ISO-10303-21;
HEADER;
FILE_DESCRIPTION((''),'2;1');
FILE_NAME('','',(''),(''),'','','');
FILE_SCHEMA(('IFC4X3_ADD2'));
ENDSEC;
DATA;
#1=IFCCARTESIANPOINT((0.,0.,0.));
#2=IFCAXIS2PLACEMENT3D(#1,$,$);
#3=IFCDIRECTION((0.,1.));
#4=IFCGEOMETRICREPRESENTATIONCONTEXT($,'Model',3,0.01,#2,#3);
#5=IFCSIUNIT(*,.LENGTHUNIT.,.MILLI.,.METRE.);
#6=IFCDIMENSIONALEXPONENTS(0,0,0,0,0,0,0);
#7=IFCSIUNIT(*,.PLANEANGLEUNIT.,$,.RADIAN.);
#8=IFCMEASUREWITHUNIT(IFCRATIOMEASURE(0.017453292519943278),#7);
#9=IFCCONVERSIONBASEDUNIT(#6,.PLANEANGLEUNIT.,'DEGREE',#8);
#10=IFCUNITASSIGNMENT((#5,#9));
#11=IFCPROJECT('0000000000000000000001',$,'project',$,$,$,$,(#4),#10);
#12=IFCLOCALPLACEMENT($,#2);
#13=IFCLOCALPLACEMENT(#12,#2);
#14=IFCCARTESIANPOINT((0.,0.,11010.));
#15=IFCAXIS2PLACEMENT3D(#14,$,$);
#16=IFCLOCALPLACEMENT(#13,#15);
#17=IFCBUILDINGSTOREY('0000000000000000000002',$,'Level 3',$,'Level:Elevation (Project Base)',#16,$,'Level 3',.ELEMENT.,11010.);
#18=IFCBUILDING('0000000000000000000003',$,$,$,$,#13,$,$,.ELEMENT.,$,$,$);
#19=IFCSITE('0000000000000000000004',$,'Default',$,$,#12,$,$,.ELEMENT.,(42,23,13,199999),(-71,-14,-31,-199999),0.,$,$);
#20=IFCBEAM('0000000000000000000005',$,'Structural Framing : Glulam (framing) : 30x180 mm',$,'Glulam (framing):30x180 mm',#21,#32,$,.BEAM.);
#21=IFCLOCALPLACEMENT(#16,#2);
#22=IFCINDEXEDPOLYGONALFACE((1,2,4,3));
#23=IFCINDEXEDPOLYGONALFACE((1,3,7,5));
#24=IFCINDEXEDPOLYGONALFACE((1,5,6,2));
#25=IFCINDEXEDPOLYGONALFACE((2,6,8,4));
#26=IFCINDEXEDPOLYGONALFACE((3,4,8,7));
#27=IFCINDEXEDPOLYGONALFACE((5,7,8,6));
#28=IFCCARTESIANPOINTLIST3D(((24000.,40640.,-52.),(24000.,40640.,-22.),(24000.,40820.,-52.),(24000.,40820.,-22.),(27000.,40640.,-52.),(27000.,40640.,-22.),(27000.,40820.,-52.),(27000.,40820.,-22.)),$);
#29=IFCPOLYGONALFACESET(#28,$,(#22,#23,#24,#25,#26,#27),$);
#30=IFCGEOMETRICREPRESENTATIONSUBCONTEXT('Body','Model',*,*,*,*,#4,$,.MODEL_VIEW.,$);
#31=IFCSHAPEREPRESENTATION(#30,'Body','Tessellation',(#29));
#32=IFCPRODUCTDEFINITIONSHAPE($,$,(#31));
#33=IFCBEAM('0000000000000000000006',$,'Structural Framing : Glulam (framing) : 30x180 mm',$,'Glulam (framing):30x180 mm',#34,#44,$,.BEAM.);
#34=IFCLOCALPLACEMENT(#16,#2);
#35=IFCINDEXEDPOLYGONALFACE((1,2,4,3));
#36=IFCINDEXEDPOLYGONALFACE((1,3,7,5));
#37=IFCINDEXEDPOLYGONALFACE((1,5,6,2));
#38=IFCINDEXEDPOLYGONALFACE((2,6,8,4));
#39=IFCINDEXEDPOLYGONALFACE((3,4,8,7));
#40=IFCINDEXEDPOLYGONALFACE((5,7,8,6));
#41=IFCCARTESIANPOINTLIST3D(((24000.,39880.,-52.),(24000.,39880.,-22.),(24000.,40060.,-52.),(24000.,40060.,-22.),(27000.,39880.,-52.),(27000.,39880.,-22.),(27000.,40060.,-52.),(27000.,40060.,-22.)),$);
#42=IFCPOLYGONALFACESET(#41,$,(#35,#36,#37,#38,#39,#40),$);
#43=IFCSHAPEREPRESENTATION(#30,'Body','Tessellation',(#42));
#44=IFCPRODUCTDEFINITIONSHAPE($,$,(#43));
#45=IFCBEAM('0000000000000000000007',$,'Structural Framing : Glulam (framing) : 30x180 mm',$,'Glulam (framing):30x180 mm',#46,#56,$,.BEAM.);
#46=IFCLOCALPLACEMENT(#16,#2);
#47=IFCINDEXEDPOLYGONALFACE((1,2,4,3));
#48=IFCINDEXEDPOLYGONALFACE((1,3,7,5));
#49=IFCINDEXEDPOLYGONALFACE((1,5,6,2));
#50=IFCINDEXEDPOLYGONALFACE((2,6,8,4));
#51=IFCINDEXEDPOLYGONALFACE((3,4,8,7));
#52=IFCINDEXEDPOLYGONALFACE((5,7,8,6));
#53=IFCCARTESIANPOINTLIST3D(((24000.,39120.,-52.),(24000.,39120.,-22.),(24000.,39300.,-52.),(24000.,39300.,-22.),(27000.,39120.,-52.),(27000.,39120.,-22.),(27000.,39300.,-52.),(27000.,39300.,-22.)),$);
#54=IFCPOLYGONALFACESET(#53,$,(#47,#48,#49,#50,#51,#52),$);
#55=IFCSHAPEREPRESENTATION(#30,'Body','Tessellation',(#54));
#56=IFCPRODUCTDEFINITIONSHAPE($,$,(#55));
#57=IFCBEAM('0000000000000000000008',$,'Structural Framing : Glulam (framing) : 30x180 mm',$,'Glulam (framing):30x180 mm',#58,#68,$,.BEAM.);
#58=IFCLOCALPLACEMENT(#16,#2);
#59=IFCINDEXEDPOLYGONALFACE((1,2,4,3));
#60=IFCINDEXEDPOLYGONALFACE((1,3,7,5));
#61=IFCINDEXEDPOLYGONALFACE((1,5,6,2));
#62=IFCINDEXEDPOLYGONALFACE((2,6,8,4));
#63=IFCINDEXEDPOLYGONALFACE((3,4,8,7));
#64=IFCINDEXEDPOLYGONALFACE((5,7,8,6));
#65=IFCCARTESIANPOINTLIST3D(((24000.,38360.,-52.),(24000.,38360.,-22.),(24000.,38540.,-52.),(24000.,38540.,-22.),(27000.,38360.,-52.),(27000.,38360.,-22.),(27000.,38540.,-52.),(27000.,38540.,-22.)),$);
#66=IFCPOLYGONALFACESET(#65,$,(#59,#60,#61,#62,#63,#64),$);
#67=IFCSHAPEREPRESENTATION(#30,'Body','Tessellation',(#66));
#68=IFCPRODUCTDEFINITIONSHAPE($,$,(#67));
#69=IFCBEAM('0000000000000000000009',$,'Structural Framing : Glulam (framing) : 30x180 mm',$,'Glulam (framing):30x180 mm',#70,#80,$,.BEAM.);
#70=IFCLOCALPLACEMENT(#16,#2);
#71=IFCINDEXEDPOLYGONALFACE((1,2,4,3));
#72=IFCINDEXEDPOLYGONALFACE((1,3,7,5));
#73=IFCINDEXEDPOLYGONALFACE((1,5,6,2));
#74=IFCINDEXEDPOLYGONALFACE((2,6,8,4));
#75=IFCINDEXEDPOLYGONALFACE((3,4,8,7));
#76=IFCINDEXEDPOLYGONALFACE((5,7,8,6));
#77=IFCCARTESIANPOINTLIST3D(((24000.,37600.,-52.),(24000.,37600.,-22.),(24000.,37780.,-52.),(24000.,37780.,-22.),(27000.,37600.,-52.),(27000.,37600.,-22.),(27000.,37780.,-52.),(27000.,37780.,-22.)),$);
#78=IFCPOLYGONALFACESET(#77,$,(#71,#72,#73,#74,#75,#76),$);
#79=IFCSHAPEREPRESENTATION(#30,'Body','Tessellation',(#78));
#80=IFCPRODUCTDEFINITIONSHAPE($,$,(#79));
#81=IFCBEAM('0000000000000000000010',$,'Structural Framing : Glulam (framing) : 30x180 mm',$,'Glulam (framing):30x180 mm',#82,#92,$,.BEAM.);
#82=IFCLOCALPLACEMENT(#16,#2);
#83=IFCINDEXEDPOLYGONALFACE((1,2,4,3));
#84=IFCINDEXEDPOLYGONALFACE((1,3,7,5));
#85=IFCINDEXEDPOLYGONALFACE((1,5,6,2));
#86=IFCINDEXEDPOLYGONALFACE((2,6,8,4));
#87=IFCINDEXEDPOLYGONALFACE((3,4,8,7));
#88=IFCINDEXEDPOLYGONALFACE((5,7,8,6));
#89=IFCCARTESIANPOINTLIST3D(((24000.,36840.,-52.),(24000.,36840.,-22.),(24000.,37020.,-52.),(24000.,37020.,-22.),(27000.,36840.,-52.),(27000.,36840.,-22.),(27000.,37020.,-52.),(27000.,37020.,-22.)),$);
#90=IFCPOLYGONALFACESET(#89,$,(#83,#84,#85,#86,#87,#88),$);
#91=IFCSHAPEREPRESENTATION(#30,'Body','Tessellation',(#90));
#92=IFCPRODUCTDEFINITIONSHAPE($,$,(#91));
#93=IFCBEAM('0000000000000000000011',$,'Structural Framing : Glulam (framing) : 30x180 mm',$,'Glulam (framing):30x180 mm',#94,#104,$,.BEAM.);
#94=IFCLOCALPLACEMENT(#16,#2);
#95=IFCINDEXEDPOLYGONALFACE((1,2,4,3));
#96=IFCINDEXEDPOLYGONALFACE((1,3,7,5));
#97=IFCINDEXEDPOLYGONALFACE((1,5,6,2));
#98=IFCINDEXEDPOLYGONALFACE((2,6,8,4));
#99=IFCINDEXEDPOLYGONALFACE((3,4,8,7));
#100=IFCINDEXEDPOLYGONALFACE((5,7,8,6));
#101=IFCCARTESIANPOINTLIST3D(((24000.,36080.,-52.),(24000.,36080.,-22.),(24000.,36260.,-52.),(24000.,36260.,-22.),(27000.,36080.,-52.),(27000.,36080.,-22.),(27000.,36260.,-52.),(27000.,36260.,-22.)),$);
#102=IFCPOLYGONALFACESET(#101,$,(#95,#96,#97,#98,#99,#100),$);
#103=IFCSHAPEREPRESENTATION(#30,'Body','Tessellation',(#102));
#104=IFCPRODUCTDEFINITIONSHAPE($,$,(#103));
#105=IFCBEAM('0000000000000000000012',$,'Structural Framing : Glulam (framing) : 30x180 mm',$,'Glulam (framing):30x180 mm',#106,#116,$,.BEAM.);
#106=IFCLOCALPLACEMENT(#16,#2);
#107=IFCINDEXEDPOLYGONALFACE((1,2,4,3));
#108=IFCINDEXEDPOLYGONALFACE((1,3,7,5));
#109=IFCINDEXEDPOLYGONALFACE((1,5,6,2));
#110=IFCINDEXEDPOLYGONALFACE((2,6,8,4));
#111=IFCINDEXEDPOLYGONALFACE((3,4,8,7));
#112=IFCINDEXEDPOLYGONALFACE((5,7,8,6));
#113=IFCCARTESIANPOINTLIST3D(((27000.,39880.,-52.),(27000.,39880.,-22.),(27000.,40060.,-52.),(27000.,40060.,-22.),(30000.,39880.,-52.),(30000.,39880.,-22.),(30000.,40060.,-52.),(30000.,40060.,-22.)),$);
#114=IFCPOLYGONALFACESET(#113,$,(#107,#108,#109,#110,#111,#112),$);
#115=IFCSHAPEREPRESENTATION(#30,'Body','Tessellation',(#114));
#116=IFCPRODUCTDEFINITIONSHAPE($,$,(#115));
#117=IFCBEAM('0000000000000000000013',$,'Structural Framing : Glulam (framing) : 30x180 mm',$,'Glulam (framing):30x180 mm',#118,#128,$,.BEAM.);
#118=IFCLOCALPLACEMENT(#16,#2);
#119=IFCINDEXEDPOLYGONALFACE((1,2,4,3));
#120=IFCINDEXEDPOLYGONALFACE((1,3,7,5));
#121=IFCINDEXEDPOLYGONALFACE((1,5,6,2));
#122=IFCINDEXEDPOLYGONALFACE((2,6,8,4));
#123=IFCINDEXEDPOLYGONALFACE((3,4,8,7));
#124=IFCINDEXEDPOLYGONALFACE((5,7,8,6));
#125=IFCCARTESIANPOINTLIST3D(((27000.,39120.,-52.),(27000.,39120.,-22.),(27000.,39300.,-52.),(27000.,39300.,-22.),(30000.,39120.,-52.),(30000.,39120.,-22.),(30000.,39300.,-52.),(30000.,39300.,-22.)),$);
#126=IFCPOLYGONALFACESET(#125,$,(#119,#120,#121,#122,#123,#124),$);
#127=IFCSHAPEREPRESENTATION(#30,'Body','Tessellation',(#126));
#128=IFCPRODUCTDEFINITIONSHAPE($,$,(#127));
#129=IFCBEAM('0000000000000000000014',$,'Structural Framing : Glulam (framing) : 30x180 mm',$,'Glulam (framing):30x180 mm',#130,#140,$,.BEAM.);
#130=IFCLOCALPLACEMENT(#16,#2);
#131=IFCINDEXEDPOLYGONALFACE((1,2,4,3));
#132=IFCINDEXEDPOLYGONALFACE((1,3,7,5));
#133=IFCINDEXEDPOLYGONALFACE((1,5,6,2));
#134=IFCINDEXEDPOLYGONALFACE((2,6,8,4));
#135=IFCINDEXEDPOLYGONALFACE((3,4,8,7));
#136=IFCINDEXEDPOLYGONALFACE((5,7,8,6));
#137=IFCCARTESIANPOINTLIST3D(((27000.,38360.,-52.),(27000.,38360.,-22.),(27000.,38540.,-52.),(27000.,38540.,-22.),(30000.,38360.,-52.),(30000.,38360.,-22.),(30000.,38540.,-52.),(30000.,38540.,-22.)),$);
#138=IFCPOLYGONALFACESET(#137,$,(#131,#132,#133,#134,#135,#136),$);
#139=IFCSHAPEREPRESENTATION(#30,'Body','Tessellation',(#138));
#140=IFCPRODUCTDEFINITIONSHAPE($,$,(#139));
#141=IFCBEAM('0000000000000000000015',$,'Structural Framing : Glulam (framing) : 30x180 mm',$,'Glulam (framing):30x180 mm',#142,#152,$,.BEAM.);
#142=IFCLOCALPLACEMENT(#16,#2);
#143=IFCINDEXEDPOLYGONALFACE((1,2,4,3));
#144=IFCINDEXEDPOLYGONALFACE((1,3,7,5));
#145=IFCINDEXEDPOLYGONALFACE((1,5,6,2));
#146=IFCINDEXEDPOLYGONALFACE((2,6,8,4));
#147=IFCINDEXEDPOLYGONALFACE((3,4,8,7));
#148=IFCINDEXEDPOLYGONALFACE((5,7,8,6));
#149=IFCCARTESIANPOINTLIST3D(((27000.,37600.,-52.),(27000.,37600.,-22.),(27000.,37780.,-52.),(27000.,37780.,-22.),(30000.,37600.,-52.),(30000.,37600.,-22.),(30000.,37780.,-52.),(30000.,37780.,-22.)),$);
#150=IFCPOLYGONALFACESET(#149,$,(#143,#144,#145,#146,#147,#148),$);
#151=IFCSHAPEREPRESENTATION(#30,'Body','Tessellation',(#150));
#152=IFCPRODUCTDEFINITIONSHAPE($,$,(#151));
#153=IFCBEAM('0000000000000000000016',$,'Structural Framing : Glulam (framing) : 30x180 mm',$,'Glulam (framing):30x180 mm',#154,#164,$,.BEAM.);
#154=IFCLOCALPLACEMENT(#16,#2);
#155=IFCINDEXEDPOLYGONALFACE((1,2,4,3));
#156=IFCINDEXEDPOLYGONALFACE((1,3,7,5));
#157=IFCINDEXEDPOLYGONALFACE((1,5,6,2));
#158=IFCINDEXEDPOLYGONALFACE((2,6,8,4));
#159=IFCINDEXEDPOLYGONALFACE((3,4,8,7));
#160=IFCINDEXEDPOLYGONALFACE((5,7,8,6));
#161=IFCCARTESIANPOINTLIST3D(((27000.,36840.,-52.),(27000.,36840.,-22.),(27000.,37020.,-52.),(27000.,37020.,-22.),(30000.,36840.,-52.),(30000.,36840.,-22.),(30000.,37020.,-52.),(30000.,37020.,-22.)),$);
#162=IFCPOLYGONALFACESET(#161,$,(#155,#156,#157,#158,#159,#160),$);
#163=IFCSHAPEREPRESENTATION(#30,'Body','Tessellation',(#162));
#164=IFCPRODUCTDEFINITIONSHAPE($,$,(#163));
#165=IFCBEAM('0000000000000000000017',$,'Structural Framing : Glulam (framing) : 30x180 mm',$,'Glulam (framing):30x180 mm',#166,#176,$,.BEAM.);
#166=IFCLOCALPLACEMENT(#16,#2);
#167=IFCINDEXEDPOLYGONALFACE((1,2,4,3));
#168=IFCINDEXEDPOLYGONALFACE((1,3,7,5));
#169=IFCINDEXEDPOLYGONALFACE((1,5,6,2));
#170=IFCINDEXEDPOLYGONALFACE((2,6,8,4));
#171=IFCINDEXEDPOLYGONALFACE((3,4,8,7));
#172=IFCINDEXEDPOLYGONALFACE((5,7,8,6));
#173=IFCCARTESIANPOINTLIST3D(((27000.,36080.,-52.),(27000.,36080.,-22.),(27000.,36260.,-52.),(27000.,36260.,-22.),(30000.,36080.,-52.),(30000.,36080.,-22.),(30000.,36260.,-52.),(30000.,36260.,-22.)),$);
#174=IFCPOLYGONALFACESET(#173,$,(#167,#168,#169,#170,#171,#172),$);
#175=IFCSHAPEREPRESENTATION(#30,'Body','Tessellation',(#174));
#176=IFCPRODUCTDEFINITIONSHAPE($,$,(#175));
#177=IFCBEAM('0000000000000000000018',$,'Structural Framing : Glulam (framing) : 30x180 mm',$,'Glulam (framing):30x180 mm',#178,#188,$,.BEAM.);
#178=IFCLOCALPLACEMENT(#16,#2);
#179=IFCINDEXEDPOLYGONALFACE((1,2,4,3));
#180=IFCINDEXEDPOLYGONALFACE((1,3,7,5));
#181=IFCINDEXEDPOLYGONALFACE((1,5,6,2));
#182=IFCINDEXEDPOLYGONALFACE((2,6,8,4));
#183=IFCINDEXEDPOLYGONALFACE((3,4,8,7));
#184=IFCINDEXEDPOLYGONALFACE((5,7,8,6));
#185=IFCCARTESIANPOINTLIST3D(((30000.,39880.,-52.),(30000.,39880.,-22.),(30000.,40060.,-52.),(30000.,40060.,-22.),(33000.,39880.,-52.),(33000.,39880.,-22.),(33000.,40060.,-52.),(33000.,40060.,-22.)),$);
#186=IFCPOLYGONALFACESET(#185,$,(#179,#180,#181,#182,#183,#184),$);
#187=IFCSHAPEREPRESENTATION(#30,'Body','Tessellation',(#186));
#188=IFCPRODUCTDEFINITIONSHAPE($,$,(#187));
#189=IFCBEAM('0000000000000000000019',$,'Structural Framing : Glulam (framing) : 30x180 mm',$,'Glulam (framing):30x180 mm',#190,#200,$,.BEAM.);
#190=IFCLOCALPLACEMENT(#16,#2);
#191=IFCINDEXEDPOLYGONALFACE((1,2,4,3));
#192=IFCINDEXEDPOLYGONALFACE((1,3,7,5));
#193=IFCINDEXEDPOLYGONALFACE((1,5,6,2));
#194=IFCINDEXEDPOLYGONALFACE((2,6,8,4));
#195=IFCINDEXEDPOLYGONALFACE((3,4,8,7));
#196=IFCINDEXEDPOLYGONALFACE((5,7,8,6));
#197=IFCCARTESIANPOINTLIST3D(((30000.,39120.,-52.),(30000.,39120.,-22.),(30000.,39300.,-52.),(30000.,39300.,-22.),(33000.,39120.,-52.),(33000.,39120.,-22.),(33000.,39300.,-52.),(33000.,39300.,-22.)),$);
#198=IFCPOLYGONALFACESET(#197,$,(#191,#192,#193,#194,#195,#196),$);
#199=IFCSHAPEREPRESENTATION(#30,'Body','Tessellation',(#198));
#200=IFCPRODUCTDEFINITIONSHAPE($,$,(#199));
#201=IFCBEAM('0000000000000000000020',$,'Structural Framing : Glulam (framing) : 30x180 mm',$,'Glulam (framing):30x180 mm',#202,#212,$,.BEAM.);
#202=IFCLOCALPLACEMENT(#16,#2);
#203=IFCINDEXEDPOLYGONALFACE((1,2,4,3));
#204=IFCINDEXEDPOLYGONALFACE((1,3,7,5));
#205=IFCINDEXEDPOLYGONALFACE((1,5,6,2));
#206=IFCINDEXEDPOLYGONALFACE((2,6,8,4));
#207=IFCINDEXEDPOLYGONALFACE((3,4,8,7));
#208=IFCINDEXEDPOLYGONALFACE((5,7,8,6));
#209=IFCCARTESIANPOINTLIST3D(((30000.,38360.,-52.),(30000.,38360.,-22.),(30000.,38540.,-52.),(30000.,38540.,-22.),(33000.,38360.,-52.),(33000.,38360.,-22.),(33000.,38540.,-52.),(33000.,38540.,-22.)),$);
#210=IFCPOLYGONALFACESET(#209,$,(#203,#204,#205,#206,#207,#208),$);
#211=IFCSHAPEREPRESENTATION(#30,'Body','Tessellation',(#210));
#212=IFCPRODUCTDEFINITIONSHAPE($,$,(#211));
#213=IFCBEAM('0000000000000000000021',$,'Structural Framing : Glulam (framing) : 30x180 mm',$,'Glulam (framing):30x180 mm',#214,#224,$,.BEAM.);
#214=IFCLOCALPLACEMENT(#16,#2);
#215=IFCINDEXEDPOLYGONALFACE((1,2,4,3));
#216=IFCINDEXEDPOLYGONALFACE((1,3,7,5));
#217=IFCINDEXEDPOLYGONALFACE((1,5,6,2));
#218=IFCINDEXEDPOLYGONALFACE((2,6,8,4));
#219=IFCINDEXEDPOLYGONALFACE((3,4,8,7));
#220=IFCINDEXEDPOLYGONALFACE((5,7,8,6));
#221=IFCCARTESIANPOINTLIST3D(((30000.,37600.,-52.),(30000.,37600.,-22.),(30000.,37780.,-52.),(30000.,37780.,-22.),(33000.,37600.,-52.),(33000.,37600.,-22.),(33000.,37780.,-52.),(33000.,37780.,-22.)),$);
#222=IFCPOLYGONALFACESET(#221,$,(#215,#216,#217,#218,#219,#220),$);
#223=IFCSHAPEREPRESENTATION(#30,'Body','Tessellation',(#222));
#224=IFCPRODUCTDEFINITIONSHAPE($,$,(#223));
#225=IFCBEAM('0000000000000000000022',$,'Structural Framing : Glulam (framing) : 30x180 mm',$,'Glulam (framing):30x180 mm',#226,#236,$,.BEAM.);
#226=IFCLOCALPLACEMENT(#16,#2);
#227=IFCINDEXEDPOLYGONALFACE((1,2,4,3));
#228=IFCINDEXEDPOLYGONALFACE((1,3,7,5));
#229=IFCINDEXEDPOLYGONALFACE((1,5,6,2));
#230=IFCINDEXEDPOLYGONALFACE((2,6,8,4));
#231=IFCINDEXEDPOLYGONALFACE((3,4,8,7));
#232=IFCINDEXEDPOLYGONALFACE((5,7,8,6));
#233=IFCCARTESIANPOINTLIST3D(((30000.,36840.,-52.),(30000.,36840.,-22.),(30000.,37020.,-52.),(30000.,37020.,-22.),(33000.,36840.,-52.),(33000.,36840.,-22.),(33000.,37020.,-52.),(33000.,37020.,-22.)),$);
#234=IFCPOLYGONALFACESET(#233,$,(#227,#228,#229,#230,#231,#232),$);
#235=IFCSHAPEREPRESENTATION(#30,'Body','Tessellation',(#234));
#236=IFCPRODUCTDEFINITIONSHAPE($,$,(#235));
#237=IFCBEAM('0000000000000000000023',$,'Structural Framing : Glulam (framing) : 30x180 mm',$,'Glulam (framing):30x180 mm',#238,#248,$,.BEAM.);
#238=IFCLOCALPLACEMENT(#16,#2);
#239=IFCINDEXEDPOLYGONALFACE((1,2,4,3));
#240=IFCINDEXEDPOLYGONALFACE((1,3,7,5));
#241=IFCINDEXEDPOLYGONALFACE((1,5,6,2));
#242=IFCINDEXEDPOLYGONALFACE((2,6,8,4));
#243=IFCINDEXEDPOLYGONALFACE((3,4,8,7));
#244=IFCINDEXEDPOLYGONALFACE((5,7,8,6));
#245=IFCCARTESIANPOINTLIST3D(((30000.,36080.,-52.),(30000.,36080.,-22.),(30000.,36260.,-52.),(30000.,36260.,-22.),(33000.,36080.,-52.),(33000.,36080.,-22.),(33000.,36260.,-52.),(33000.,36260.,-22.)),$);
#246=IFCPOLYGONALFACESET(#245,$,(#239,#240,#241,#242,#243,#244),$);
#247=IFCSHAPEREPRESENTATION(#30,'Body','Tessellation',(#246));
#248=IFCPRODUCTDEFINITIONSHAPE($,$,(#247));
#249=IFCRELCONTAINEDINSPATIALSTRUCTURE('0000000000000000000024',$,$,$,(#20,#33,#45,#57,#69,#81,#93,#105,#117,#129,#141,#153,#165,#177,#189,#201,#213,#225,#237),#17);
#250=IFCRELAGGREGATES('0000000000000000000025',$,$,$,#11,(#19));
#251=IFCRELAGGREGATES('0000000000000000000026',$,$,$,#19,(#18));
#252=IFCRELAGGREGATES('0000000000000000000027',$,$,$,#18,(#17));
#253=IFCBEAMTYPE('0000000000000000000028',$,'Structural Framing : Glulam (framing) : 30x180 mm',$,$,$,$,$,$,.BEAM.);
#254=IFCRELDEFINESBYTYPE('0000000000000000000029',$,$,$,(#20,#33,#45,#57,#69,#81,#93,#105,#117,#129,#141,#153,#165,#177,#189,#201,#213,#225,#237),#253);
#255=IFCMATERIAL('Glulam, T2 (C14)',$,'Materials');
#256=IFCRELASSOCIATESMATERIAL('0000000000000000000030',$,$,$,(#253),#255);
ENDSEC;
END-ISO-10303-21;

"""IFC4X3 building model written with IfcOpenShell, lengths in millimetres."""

from ifc_helpers import new_model, entity, si_unit, converted_unit, direction, frame, origin, origin_2d_with_axis, place, context, subcontext, project, spatial, rectangle, extrude, source, transform, mapped, material, material_profile, profile_set, type_object, type_shapes, element, save


model = new_model("IFC4X3")

# Units and contexts
model_context = context("Model", 3, precision=0.01, world=origin(), true_north=direction((0.0, 1.0)))
body_context = subcontext(model_context, "Body", "Model", "MODEL_VIEW")
ifc_project = project(units=[si_unit("LENGTHUNIT", "METRE", prefix="MILLI"), converted_unit("PLANEANGLEUNIT", "DEGREE", entity("IfcRatioMeasure", 0.017453292519943278), si_unit("PLANEANGLEUNIT", "RADIAN"), dimensions=[0, 0, 0, 0, 0, 0, 0])], contexts=[model_context])

# Site, building, storey
site_placement = place(None, origin())
site = spatial("IfcSite", under=ifc_project, at=site_placement, Name="Default", CompositionType="ELEMENT", RefLatitude=(42, 23, 13, 199999), RefLongitude=(-71, -14, -31, -199999), RefElevation=0.0)
building_placement = place(site_placement, origin())
building = spatial("IfcBuilding", under=site, at=building_placement, CompositionType="ELEMENT")
storey_placement = place(building_placement, frame((0.0, 0.0, 11010.0)))
storey = spatial("IfcBuildingStorey", under=building, at=storey_placement, Name="Level 3", ObjectType="Level:Elevation (Project Base)", LongName="Level 3", CompositionType="ELEMENT", Elevation=11010.0)

# Beams
ifc_material_1 = material(Name="Glulam, T2 (C14)", Category="Materials")
ifc_material_profile_1 = material_profile(ifc_material_1, rectangle(XDim=30.0, YDim=180.0, at=origin_2d_with_axis()), Name="30x180 mm")
ifc_profile_set_1 = profile_set([ifc_material_profile_1], Name="30x180 mm")
beam_type_1 = type_object("IfcBeamType", Name="Structural Framing : Glulam (framing) : 30x180 mm", PredefinedType="BEAM", material=ifc_profile_set_1)
shared_shape_1 = source(origin(), body_context, "Body", "SweptSolid", [
    extrude(rectangle(XDim=30.0, YDim=180.0, at=origin_2d_with_axis()), frame((500.0, 0.0, 0.0), z_axis=(1.0, 0.0, 0.0), x_axis=(0.0, 0.0, -1.0)), (0.0, 0.0, 1.0), 3000.0),
])
type_shapes(beam_type_1, [shared_shape_1])
for number, where, name in (
    (1, (23500.0, 40730.0, -37.0), "Structural Framing : Glulam (framing) : 30x180 mm"),
    (2, (23500.0, 39970.0, -37.0), "Structural Framing : Glulam (framing) : 30x180 mm"),
    (3, (23500.0, 39210.0, -37.0), "Structural Framing : Glulam (framing) : 30x180 mm"),
    (4, (23500.0, 38450.0, -37.0), "Structural Framing : Glulam (framing) : 30x180 mm"),
    (5, (23500.0, 37690.0, -37.0), "Structural Framing : Glulam (framing) : 30x180 mm"),
    (6, (23500.0, 36930.0, -37.0), "Structural Framing : Glulam (framing) : 30x180 mm"),
    (7, (23500.0, 36170.0, -37.0), "Structural Framing : Glulam (framing) : 30x180 mm"),
    (8, (26500.0, 39970.0, -37.0), "Structural Framing : Glulam (framing) : 30x180 mm"),
    (9, (26500.0, 39210.0, -37.0), "Structural Framing : Glulam (framing) : 30x180 mm"),
    (10, (26500.0, 38450.0, -37.0), "Structural Framing : Glulam (framing) : 30x180 mm"),
    (11, (26500.0, 37690.0, -37.0), "Structural Framing : Glulam (framing) : 30x180 mm"),
    (12, (26500.0, 36930.0, -37.0), "Structural Framing : Glulam (framing) : 30x180 mm"),
    (13, (26500.0, 36170.0, -37.0), "Structural Framing : Glulam (framing) : 30x180 mm"),
    (14, (29500.0, 39970.0, -37.0), "Structural Framing : Glulam (framing) : 30x180 mm"),
    (15, (29500.0, 39210.0, -37.0), "Structural Framing : Glulam (framing) : 30x180 mm"),
    (16, (29500.0, 38450.0, -37.0), "Structural Framing : Glulam (framing) : 30x180 mm"),
    (17, (29500.0, 37690.0, -37.0), "Structural Framing : Glulam (framing) : 30x180 mm"),
    (18, (29500.0, 36930.0, -37.0), "Structural Framing : Glulam (framing) : 30x180 mm"),
    (19, (29500.0, 36170.0, -37.0), "Structural Framing : Glulam (framing) : 30x180 mm"),
):
    element("IfcBeam", number, at=place(storey_placement, frame(where)), inside=storey, type_object=beam_type_1, Name=name, ObjectType="Glulam (framing):30x180 mm", PredefinedType="BEAM", context=body_context, shape_type="MappedRepresentation", body=[
        mapped(shared_shape_1, transform((0.0, 0.0, 0.0), scale=1.0)),
    ])

save(model, "model.ifc")
